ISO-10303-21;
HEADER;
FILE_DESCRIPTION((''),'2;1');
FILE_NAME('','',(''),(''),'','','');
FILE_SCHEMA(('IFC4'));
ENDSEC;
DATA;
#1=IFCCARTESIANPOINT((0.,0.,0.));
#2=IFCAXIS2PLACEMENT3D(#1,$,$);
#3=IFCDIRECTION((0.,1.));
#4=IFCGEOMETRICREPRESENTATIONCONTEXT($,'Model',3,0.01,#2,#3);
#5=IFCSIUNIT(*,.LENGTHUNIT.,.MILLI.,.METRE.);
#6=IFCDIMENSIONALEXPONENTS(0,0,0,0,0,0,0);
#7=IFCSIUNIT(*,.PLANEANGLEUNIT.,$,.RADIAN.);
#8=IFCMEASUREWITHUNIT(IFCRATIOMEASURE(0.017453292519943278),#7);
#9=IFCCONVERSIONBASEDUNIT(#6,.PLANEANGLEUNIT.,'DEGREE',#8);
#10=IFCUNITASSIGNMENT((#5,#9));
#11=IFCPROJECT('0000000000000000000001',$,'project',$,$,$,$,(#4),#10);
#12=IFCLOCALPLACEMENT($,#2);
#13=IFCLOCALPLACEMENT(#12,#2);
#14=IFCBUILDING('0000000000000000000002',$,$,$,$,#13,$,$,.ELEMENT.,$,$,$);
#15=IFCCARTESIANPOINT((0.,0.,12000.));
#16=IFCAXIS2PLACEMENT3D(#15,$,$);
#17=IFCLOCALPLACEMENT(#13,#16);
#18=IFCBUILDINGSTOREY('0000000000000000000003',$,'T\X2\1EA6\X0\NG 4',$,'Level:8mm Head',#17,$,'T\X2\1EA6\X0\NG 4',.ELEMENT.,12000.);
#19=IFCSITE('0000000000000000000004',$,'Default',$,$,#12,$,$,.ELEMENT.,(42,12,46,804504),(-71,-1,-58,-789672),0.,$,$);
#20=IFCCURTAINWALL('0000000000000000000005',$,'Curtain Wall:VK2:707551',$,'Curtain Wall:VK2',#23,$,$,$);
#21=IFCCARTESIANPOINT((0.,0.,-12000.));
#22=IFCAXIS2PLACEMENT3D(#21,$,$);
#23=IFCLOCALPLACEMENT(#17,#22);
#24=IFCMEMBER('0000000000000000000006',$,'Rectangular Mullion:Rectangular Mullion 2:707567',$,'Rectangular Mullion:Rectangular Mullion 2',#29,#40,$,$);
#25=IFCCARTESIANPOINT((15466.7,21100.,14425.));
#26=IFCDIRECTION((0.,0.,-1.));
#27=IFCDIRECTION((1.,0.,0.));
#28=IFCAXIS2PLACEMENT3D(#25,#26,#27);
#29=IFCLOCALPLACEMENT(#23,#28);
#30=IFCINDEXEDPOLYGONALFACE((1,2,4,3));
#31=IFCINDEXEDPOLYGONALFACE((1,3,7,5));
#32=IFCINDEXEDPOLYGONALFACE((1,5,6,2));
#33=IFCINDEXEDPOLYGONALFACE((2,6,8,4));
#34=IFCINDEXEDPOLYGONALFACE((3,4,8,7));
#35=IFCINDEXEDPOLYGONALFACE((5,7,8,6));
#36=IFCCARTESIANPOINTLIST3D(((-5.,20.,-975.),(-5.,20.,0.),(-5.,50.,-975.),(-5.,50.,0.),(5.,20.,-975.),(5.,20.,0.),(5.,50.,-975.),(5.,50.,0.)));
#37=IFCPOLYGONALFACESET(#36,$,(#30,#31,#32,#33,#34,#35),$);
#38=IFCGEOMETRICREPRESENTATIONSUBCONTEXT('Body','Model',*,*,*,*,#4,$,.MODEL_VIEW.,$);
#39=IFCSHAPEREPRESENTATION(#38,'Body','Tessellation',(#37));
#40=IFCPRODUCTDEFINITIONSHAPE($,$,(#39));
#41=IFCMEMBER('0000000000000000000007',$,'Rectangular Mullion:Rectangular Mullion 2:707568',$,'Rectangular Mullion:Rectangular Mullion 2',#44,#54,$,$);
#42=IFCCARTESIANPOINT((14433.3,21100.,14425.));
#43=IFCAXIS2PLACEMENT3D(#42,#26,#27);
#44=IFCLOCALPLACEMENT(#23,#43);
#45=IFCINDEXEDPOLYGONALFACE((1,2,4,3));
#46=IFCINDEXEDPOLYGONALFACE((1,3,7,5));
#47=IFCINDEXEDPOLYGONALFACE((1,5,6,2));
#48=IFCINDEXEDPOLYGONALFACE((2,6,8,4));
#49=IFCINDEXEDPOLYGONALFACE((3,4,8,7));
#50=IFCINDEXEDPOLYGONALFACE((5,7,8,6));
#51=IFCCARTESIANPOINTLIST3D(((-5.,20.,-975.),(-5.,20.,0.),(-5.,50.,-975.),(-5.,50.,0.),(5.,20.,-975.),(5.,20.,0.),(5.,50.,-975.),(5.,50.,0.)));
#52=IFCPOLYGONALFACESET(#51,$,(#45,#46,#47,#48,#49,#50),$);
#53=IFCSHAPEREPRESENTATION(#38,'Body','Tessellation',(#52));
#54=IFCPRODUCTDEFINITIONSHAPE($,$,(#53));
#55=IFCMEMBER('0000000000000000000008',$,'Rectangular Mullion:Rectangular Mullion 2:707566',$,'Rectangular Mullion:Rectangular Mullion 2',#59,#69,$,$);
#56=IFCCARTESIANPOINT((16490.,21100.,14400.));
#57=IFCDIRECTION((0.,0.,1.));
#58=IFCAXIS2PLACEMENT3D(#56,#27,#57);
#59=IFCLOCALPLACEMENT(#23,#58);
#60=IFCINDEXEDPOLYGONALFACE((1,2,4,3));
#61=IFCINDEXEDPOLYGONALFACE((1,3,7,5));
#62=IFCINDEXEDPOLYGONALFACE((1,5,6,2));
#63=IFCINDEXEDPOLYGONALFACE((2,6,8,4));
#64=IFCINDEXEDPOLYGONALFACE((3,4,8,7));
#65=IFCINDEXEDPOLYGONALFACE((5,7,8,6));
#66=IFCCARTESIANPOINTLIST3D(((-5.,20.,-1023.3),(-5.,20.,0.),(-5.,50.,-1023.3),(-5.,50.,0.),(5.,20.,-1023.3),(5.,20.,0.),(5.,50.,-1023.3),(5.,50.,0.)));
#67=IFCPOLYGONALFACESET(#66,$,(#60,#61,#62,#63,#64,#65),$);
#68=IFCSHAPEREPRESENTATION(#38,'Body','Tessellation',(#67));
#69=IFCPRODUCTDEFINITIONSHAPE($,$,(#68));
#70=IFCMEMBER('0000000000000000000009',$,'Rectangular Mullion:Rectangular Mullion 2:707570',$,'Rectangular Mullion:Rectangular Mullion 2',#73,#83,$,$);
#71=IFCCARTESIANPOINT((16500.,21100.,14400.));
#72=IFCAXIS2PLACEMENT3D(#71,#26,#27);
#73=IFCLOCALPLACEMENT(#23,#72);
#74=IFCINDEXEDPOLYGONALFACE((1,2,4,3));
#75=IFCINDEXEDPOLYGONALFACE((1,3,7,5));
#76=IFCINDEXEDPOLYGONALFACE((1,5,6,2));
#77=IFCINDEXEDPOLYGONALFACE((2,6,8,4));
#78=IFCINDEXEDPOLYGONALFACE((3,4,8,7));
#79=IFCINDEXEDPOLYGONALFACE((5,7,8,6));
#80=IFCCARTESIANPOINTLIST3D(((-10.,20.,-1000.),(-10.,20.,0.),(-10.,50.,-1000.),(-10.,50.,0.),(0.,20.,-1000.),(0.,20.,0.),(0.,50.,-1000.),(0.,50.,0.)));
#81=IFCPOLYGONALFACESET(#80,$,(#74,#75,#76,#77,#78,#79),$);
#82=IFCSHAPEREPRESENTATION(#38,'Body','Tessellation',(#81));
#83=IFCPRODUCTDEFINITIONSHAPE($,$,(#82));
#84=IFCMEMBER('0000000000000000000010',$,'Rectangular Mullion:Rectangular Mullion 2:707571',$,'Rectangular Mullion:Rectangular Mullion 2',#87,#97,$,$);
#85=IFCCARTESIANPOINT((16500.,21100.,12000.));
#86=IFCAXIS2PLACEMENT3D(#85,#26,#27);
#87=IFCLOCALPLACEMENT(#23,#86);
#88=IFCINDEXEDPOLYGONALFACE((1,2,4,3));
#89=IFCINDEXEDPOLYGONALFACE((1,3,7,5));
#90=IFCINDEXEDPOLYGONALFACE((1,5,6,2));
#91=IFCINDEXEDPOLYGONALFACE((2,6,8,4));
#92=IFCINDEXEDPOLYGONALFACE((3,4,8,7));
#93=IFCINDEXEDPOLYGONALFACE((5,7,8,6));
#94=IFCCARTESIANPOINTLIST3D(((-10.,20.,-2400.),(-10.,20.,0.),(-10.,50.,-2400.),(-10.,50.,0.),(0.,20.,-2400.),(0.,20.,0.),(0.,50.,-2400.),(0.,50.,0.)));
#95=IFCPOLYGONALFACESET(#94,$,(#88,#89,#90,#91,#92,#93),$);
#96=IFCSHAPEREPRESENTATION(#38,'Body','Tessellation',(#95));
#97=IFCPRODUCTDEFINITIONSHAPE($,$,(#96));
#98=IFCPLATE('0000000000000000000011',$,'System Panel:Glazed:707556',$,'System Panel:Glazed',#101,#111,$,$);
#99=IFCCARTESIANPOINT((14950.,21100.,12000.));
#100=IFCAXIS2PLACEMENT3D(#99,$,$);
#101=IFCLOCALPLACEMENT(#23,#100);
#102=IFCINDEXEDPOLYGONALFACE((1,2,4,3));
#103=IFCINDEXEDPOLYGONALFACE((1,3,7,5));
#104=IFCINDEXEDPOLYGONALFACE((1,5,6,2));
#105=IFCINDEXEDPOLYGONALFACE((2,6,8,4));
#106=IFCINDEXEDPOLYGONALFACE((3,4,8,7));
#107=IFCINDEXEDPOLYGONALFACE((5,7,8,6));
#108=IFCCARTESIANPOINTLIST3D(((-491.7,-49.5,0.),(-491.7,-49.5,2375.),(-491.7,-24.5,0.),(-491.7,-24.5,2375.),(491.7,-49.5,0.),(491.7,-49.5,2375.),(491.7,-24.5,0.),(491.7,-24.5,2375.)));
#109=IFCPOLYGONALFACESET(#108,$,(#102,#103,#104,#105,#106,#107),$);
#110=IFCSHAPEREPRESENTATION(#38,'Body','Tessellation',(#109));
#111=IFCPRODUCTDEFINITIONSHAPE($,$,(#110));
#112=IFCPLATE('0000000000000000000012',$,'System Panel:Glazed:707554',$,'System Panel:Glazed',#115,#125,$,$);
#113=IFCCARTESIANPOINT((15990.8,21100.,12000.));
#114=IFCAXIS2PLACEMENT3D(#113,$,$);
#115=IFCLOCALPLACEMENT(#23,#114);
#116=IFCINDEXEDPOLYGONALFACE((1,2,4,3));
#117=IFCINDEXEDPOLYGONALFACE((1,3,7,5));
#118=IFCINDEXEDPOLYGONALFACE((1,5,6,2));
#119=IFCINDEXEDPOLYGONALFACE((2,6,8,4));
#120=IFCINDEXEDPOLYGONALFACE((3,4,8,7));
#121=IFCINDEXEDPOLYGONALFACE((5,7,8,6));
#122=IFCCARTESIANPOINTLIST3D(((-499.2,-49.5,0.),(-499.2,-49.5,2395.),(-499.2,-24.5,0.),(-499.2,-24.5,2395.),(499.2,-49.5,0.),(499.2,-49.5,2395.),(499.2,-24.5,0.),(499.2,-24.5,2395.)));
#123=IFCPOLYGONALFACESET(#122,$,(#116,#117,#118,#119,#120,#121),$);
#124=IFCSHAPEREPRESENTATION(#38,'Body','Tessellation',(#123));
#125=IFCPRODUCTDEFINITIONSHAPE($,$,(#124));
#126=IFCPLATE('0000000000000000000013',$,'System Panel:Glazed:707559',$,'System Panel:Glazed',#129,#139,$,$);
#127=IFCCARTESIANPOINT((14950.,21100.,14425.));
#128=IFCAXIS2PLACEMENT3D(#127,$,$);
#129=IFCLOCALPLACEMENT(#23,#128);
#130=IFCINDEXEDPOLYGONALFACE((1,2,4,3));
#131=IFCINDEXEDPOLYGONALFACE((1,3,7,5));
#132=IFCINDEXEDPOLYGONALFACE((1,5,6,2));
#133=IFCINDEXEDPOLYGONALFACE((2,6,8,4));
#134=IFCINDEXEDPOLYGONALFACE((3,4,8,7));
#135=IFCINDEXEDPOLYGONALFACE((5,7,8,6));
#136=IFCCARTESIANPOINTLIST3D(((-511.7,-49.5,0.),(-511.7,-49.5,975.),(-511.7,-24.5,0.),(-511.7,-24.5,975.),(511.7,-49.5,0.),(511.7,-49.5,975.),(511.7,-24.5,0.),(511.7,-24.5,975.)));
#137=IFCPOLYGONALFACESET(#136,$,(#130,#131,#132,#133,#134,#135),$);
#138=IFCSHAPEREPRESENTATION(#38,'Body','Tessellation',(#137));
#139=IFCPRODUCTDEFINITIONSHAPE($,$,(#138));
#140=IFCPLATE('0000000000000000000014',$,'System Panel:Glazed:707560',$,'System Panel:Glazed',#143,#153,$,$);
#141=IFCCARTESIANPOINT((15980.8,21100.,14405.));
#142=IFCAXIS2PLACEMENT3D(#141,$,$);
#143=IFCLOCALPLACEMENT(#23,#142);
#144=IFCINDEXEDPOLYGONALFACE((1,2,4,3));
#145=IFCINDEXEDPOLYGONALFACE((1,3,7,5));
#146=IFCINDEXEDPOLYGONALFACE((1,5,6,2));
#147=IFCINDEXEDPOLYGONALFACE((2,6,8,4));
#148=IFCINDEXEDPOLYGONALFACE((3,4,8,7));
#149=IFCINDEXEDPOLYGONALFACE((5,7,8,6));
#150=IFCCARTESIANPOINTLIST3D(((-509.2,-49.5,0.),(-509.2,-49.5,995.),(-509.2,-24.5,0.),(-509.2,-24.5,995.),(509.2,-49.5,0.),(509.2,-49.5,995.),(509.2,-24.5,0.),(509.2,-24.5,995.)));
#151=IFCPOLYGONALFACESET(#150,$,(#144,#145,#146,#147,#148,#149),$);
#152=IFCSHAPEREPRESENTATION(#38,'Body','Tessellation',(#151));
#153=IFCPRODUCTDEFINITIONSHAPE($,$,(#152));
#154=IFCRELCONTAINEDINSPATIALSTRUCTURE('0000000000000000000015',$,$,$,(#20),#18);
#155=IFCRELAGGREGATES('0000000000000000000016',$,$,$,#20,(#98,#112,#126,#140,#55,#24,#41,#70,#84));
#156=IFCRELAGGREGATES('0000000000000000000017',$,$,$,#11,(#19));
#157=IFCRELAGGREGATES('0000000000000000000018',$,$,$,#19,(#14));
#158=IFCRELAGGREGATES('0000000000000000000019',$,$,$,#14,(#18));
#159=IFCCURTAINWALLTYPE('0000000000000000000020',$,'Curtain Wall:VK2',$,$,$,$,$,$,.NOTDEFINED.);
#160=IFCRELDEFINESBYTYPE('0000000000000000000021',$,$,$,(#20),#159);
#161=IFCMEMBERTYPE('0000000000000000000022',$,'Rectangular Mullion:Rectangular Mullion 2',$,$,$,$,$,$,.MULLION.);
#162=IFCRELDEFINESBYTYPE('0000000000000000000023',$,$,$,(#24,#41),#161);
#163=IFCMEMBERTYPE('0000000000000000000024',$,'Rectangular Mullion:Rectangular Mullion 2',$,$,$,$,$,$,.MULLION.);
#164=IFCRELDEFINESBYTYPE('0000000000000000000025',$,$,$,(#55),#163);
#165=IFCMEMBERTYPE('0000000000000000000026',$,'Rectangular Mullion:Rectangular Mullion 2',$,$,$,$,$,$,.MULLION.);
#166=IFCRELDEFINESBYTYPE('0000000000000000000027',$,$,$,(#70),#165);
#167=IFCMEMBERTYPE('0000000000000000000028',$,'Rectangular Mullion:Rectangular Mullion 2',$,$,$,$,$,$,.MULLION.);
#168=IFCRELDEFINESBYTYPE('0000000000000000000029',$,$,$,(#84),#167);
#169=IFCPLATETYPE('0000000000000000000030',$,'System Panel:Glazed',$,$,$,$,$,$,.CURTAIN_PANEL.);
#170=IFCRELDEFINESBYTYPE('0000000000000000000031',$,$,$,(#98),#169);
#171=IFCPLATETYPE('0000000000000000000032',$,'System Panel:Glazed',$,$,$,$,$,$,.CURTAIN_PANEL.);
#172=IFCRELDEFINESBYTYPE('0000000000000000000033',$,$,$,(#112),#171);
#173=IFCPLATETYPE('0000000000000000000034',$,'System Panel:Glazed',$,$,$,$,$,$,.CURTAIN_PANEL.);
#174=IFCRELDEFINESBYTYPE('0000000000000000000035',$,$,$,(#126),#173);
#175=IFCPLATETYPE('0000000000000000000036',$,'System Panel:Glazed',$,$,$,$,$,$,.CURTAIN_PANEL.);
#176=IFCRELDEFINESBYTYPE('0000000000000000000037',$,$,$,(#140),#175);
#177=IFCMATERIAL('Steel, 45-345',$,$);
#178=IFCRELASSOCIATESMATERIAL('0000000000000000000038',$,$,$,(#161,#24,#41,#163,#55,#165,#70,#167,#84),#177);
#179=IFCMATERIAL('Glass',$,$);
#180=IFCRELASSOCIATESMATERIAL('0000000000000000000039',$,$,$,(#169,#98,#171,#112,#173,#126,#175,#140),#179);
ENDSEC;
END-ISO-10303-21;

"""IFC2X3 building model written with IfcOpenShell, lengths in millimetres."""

from ifc_helpers import new_model, entity, si_unit, converted_unit, direction, frame, frame_2d, origin, origin_2d_with_axis, place, context, subcontext, project, spatial, rectangle, extrude, source, transform, mapped, material, type_object, type_shapes, element, aggregate, save


model = new_model("IFC2X3")

# Units and contexts
model_context = context("Model", 3, precision=0.01, world=origin(), true_north=direction((0.0, 1.0)))
body_context = subcontext(model_context, "Body", "Model", "MODEL_VIEW")
ifc_project = project(units=[si_unit("LENGTHUNIT", "METRE", prefix="MILLI"), converted_unit("PLANEANGLEUNIT", "DEGREE", entity("IfcRatioMeasure", 0.017453292519943278), si_unit("PLANEANGLEUNIT", "RADIAN"), dimensions=[0, 0, 0, 0, 0, 0, 0])], contexts=[model_context])

# Site, building, storey
site_placement = place(None, origin())
site = spatial("IfcSite", under=ifc_project, at=site_placement, Name="Default", CompositionType="ELEMENT", RefLatitude=(42, 12, 46, 804504), RefLongitude=(-71, -1, -58, -789672), RefElevation=0.0)
building_placement = place(site_placement, origin())
building = spatial("IfcBuilding", under=site, at=building_placement, CompositionType="ELEMENT")
storey_placement = place(building_placement, frame((0.0, 0.0, 12000.0)))
storey = spatial("IfcBuildingStorey", under=building, at=storey_placement, Name="TẦNG 4", ObjectType="Level:8mm Head", LongName="TẦNG 4", CompositionType="ELEMENT", Elevation=12000.0)

# Curtain wall, members, plates
curtain_wall_type = type_object("IfcCurtainWallType", Name="Curtain Wall:VK2", PredefinedType="NOTDEFINED")
curtain_wall_placement = place(storey_placement, frame((0.0, 0.0, -12000.0)))
curtain_wall = element("IfcCurtainWall", 1, at=curtain_wall_placement, inside=storey, type_object=curtain_wall_type, Name="Curtain Wall:VK2:707551", ObjectType="Curtain Wall:VK2")
ifc_material_1 = material(Name="Steel, 45-345")
member_type_1 = type_object("IfcMemberType", Name="Rectangular Mullion:Rectangular Mullion 2", PredefinedType="MULLION", material=ifc_material_1)
shared_shape_1 = source(origin(), body_context, "Body", "SweptSolid", [
    extrude(rectangle(XDim=30.0, YDim=10.0, at=origin_2d_with_axis()), frame((0.0, 35.0, -975.0), z_axis=(0.0, 0.0, 1.0), x_axis=(0.0, -1.0, 0.0)), (0.0, 0.0, 1.0), 975.0),
])
type_shapes(member_type_1, [shared_shape_1])
member_1_placement = place(curtain_wall_placement, frame((15466.7, 21100.0, 14425.0), z_axis=(0.0, 0.0, -1.0), x_axis=(1.0, 0.0, 0.0)))
member_1 = element("IfcMember", 2, at=member_1_placement, type_object=member_type_1, material=ifc_material_1, Name="Rectangular Mullion:Rectangular Mullion 2:707567", ObjectType="Rectangular Mullion:Rectangular Mullion 2", context=body_context, shape_type="MappedRepresentation", body=[
    mapped(shared_shape_1, transform((0.0, 0.0, 0.0), scale=1.0)),
])
member_2_placement = place(curtain_wall_placement, frame((14433.3, 21100.0, 14425.0), z_axis=(0.0, 0.0, -1.0), x_axis=(1.0, 0.0, 0.0)))
member_2 = element("IfcMember", 3, at=member_2_placement, type_object=member_type_1, material=ifc_material_1, Name="Rectangular Mullion:Rectangular Mullion 2:707568", ObjectType="Rectangular Mullion:Rectangular Mullion 2", context=body_context, shape_type="MappedRepresentation", body=[
    mapped(shared_shape_1, transform((0.0, 0.0, 0.0), scale=1.0)),
])
member_type_2 = type_object("IfcMemberType", Name="Rectangular Mullion:Rectangular Mullion 2", PredefinedType="MULLION", material=ifc_material_1)
shared_shape_2 = source(origin(), body_context, "Body", "SweptSolid", [
    extrude(rectangle(XDim=30.0, YDim=10.0, at=origin_2d_with_axis()), frame((0.0, 35.0, -1023.3), z_axis=(0.0, 0.0, 1.0), x_axis=(0.0, -1.0, 0.0)), (0.0, 0.0, 1.0), 1023.3),
])
type_shapes(member_type_2, [shared_shape_2])
member_3_placement = place(curtain_wall_placement, frame((16490.0, 21100.0, 14400.0), z_axis=(1.0, 0.0, 0.0), x_axis=(0.0, 0.0, 1.0)))
member_3 = element("IfcMember", 4, at=member_3_placement, type_object=member_type_2, material=ifc_material_1, Name="Rectangular Mullion:Rectangular Mullion 2:707566", ObjectType="Rectangular Mullion:Rectangular Mullion 2", context=body_context, shape_type="MappedRepresentation", body=[
    mapped(shared_shape_2, transform((0.0, 0.0, 0.0), scale=1.0)),
])
member_type_3 = type_object("IfcMemberType", Name="Rectangular Mullion:Rectangular Mullion 2", PredefinedType="MULLION", material=ifc_material_1)
shared_shape_3 = source(origin(), body_context, "Body", "SweptSolid", [
    extrude(rectangle(XDim=30.0, YDim=10.0, at=origin_2d_with_axis()), frame((-5.0, 35.0, -1000.0), z_axis=(0.0, 0.0, 1.0), x_axis=(0.0, -1.0, 0.0)), (0.0, 0.0, 1.0), 1000.0),
])
type_shapes(member_type_3, [shared_shape_3])
member_4_placement = place(curtain_wall_placement, frame((16500.0, 21100.0, 14400.0), z_axis=(0.0, 0.0, -1.0), x_axis=(1.0, 0.0, 0.0)))
member_4 = element("IfcMember", 5, at=member_4_placement, type_object=member_type_3, material=ifc_material_1, Name="Rectangular Mullion:Rectangular Mullion 2:707570", ObjectType="Rectangular Mullion:Rectangular Mullion 2", context=body_context, shape_type="MappedRepresentation", body=[
    mapped(shared_shape_3, transform((0.0, 0.0, 0.0), scale=1.0)),
])
member_type_4 = type_object("IfcMemberType", Name="Rectangular Mullion:Rectangular Mullion 2", PredefinedType="MULLION", material=ifc_material_1)
shared_shape_4 = source(origin(), body_context, "Body", "SweptSolid", [
    extrude(rectangle(XDim=30.0, YDim=10.0, at=origin_2d_with_axis()), frame((-5.0, 35.0, -2400.0), z_axis=(0.0, 0.0, 1.0), x_axis=(0.0, -1.0, 0.0)), (0.0, 0.0, 1.0), 2400.0),
])
type_shapes(member_type_4, [shared_shape_4])
member_5_placement = place(curtain_wall_placement, frame((16500.0, 21100.0, 12000.0), z_axis=(0.0, 0.0, -1.0), x_axis=(1.0, 0.0, 0.0)))
member_5 = element("IfcMember", 6, at=member_5_placement, type_object=member_type_4, material=ifc_material_1, Name="Rectangular Mullion:Rectangular Mullion 2:707571", ObjectType="Rectangular Mullion:Rectangular Mullion 2", context=body_context, shape_type="MappedRepresentation", body=[
    mapped(shared_shape_4, transform((0.0, 0.0, 0.0), scale=1.0)),
])
ifc_material_2 = material(Name="Glass")
plate_type_1 = type_object("IfcPlateType", Name="System Panel:Glazed", PredefinedType="CURTAIN_PANEL", material=ifc_material_2)
shared_shape_5 = source(origin(), body_context, "Body", "SweptSolid", [
    extrude(rectangle(XDim=25.0, YDim=983.3, at=frame_2d((0.0, 0.0), x_axis=(1.0, 0.0))), frame((0.0, -37.0, 0.0), z_axis=(0.0, 0.0, 1.0), x_axis=(0.0, 1.0, 0.0)), (0.0, 0.0, 1.0), 2375.0),
])
type_shapes(plate_type_1, [shared_shape_5])
plate_1_placement = place(curtain_wall_placement, frame((14950.0, 21100.0, 12000.0)))
plate_1 = element("IfcPlate", 7, at=plate_1_placement, type_object=plate_type_1, material=ifc_material_2, Name="System Panel:Glazed:707556", ObjectType="System Panel:Glazed", context=body_context, shape_type="MappedRepresentation", body=[
    mapped(shared_shape_5, transform((0.0, 0.0, 0.0), scale=1.0)),
])
plate_type_2 = type_object("IfcPlateType", Name="System Panel:Glazed", PredefinedType="CURTAIN_PANEL", material=ifc_material_2)
shared_shape_6 = source(origin(), body_context, "Body", "SweptSolid", [
    extrude(rectangle(XDim=25.0, YDim=998.3, at=frame_2d((0.0, 0.0), x_axis=(1.0, 0.0))), frame((0.0, -37.0, 0.0), z_axis=(0.0, 0.0, 1.0), x_axis=(0.0, 1.0, 0.0)), (0.0, 0.0, 1.0), 2395.0),
])
type_shapes(plate_type_2, [shared_shape_6])
plate_2_placement = place(curtain_wall_placement, frame((15990.8, 21100.0, 12000.0)))
plate_2 = element("IfcPlate", 8, at=plate_2_placement, type_object=plate_type_2, material=ifc_material_2, Name="System Panel:Glazed:707554", ObjectType="System Panel:Glazed", context=body_context, shape_type="MappedRepresentation", body=[
    mapped(shared_shape_6, transform((0.0, 0.0, 0.0), scale=1.0)),
])
plate_type_3 = type_object("IfcPlateType", Name="System Panel:Glazed", PredefinedType="CURTAIN_PANEL", material=ifc_material_2)
shared_shape_7 = source(origin(), body_context, "Body", "SweptSolid", [
    extrude(rectangle(XDim=25.0, YDim=1023.3, at=frame_2d((0.0, 0.0), x_axis=(1.0, 0.0))), frame((0.0, -37.0, 0.0), z_axis=(0.0, 0.0, 1.0), x_axis=(0.0, 1.0, 0.0)), (0.0, 0.0, 1.0), 975.0),
])
type_shapes(plate_type_3, [shared_shape_7])
plate_3_placement = place(curtain_wall_placement, frame((14950.0, 21100.0, 14425.0)))
plate_3 = element("IfcPlate", 9, at=plate_3_placement, type_object=plate_type_3, material=ifc_material_2, Name="System Panel:Glazed:707559", ObjectType="System Panel:Glazed", context=body_context, shape_type="MappedRepresentation", body=[
    mapped(shared_shape_7, transform((0.0, 0.0, 0.0), scale=1.0)),
])
plate_type_4 = type_object("IfcPlateType", Name="System Panel:Glazed", PredefinedType="CURTAIN_PANEL", material=ifc_material_2)
shared_shape_8 = source(origin(), body_context, "Body", "SweptSolid", [
    extrude(rectangle(XDim=25.0, YDim=1018.3, at=frame_2d((0.0, 0.0), x_axis=(1.0, 0.0))), frame((0.0, -37.0, 0.0), z_axis=(0.0, 0.0, 1.0), x_axis=(0.0, 1.0, 0.0)), (0.0, 0.0, 1.0), 995.0),
])
type_shapes(plate_type_4, [shared_shape_8])
plate_4_placement = place(curtain_wall_placement, frame((15980.8, 21100.0, 14405.0)))
plate_4 = element("IfcPlate", 10, at=plate_4_placement, type_object=plate_type_4, material=ifc_material_2, Name="System Panel:Glazed:707560", ObjectType="System Panel:Glazed", context=body_context, shape_type="MappedRepresentation", body=[
    mapped(shared_shape_8, transform((0.0, 0.0, 0.0), scale=1.0)),
])
aggregate(curtain_wall, [plate_1, plate_2, plate_3, plate_4, member_3, member_1, member_2, member_4, member_5])

save(model, "model.ifc")
